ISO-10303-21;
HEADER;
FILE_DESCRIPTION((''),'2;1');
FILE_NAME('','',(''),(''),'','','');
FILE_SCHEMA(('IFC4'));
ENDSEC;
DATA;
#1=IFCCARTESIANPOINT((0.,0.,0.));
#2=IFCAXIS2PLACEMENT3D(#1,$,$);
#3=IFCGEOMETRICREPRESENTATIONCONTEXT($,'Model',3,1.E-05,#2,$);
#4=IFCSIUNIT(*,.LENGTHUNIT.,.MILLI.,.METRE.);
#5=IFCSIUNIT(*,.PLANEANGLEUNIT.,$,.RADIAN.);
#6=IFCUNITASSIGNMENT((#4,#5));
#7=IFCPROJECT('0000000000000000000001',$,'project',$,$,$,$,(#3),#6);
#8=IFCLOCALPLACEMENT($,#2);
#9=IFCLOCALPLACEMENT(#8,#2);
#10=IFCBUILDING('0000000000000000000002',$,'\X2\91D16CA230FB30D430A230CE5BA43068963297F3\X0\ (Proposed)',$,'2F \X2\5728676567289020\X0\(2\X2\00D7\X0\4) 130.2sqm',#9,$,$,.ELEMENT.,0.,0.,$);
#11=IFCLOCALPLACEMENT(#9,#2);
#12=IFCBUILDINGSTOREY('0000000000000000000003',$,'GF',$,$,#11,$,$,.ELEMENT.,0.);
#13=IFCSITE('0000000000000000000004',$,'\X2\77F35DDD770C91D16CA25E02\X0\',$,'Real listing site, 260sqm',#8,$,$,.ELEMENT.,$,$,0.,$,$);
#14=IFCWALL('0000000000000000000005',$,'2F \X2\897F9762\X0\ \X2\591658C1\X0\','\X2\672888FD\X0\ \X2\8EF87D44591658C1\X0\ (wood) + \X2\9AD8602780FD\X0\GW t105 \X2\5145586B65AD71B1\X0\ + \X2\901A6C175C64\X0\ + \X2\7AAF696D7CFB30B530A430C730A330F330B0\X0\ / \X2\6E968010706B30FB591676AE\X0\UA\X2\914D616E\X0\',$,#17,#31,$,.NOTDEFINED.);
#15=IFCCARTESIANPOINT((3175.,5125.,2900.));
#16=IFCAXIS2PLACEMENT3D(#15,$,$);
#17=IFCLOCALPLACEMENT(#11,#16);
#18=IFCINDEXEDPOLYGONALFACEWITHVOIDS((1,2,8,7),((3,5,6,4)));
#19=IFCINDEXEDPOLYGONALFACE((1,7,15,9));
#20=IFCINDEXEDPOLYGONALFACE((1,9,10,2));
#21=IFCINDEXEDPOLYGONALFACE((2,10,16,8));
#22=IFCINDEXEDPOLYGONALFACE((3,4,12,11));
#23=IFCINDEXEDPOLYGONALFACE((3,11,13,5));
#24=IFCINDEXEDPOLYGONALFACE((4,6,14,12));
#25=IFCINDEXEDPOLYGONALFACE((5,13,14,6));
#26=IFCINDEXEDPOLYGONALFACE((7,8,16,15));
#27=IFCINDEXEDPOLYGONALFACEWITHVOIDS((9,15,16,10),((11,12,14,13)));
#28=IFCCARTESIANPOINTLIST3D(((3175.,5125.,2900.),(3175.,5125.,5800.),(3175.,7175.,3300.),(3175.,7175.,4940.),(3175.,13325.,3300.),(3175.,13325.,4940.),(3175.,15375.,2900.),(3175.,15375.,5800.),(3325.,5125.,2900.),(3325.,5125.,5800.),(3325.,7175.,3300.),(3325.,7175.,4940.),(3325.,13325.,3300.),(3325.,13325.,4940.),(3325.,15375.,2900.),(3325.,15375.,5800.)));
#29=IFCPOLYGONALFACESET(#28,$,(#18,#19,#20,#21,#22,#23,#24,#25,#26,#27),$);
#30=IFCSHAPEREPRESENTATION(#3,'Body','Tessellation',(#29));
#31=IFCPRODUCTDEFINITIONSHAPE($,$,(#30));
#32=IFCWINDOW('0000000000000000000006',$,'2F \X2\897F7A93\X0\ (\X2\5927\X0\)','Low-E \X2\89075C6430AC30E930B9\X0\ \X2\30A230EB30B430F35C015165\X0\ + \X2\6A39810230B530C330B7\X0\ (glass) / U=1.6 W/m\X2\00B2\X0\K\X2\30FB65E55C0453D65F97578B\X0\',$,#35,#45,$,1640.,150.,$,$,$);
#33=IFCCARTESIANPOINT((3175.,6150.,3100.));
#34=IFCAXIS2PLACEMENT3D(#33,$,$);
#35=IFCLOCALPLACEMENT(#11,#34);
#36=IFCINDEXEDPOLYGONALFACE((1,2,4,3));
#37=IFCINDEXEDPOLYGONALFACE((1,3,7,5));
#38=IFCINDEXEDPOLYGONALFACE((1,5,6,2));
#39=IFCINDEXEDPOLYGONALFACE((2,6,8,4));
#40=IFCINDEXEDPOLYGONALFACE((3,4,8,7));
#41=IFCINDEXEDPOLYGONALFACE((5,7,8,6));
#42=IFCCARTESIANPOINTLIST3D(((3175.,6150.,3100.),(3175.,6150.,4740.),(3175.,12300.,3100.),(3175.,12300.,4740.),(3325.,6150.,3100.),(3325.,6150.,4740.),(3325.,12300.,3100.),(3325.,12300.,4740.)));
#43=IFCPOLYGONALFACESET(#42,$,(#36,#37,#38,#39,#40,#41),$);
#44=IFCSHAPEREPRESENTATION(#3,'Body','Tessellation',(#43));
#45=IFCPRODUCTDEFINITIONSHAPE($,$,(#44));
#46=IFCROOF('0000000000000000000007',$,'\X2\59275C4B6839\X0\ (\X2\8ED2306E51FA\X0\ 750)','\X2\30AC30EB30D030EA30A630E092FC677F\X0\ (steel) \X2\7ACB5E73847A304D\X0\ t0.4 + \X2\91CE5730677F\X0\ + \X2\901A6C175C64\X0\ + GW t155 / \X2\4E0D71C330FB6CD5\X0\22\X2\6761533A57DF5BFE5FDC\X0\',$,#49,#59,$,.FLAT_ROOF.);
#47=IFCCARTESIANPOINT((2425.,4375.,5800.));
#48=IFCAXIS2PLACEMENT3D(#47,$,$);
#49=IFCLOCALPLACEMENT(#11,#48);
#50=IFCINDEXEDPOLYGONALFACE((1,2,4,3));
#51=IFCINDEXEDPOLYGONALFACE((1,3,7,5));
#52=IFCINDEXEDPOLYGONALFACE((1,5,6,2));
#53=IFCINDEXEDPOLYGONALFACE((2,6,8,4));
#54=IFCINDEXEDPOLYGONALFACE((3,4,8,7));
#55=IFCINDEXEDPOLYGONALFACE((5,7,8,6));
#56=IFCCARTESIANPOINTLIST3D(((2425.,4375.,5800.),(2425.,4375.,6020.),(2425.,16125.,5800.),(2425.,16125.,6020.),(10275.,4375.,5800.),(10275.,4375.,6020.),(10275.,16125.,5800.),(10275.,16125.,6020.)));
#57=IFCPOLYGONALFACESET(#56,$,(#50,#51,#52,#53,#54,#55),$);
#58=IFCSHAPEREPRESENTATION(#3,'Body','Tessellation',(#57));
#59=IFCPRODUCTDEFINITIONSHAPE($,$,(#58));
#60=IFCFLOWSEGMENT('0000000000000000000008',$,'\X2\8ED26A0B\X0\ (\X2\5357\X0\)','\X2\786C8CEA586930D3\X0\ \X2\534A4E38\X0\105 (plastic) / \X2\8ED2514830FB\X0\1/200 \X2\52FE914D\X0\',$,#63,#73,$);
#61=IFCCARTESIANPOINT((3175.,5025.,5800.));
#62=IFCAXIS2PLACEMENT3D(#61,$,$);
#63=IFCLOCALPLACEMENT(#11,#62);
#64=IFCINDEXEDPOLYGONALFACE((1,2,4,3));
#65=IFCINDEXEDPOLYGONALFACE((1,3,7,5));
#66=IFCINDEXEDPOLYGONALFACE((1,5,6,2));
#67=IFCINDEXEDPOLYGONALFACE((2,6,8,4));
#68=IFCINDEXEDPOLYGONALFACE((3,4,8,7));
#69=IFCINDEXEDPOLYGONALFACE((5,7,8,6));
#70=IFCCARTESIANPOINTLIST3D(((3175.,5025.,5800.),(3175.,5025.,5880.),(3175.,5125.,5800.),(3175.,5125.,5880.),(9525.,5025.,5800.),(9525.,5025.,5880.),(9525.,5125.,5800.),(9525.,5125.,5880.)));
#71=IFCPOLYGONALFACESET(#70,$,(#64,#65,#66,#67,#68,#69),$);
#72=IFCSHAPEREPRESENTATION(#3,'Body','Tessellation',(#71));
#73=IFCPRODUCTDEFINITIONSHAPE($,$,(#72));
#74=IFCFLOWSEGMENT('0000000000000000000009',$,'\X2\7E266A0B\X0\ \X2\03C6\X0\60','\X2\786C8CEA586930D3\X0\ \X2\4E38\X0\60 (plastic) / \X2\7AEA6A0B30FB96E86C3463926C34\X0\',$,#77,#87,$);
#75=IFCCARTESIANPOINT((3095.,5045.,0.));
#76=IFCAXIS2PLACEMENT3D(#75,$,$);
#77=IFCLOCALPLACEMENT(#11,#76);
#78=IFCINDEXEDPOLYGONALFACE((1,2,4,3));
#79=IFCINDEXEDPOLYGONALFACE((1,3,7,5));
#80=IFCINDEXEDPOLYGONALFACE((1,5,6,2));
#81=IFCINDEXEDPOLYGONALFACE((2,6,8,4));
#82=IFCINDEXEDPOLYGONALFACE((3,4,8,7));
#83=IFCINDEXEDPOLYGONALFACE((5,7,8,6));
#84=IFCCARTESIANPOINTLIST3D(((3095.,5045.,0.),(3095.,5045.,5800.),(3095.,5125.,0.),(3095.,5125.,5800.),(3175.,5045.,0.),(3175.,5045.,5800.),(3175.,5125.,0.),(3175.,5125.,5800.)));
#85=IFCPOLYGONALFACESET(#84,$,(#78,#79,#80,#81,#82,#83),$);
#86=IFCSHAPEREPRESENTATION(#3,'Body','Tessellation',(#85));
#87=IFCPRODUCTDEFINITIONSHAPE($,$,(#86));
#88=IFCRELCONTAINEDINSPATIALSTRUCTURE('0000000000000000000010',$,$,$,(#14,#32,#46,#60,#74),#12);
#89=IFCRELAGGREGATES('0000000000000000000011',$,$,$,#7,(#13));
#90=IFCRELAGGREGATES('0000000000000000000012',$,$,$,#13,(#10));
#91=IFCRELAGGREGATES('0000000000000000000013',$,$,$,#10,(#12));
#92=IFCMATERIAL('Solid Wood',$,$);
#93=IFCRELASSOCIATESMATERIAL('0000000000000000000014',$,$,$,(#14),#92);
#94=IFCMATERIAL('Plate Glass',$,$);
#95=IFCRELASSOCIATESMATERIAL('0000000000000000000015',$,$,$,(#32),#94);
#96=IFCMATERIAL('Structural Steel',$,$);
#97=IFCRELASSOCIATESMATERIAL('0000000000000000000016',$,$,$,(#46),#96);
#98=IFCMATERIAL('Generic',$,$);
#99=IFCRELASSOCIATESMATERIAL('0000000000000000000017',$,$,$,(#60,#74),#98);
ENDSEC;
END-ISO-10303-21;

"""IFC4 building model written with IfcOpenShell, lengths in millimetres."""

from ifc_helpers import new_model, si_unit, frame, frame_2d, origin, place, context, project, spatial, rectangle, extrude, material, element, fill, save


model = new_model("IFC4")

# Units and contexts
model_context = context("Model", 3, precision=1e-05, world=origin())
ifc_project = project(units=[si_unit("LENGTHUNIT", "METRE", prefix="MILLI"), si_unit("PLANEANGLEUNIT", "RADIAN")], contexts=[model_context])

# Site, building, storey
site_placement = place(None, origin())
site = spatial("IfcSite", under=ifc_project, at=site_placement, Name="石川県金沢市", ObjectType="Real listing site, 260sqm", CompositionType="ELEMENT", RefElevation=0.0)
building_placement = place(site_placement, origin())
building = spatial("IfcBuilding", under=site, at=building_placement, Name="金沢・ピアノ室と防音 (Proposed)", ObjectType="2F 在来木造(2×4) 130.2sqm", CompositionType="ELEMENT", ElevationOfRefHeight=0.0, ElevationOfTerrain=0.0)
storey_placement = place(building_placement, origin())
storey = spatial("IfcBuildingStorey", under=building, at=storey_placement, Name="GF", CompositionType="ELEMENT", Elevation=0.0)

# Shared definitions
ifc_material_1 = material(Name="Solid Wood")

# Shared definitions
ifc_material_2 = material(Name="Plate Glass")

# Wall, opening, window
wall_1_placement = place(storey_placement, frame((3175.0, 5125.0, 2900.0)))
wall_1 = element("IfcWall", 1, at=wall_1_placement, inside=storey, material=ifc_material_1, Name="2F 西面 外壁", Description="木製 軸組外壁 (wood) + 高性能GW t105 充填断熱 + 通気層 + 窯業系サイディング / 準耐火・外皮UA配慮", PredefinedType="NOTDEFINED", context=model_context, shape_type="SweptSolid", body=[
    extrude(rectangle(XDim=150.0, YDim=10250.0, at=frame_2d((75.0, 5125.0))), frame((3175.0, 5125.0, 2900.0)), (0.0, 0.0, 1.0), 2900.0),
])
opening_1_placement = place(storey_placement, frame((3175.0, 6150.0, 3100.0)))
opening_1 = element("IfcOpeningElement", 2, at=opening_1_placement, cuts=wall_1, PredefinedType="NOTDEFINED", context=model_context, shape_type="SweptSolid", body=[
    extrude(rectangle(XDim=150.0, YDim=6150.0, at=frame_2d((75.0, 3075.0))), frame((3175.0, 6150.0, 3100.0)), (0.0, 0.0, 1.0), 1640.0),
])
window_1_placement = place(storey_placement, frame((3175.0, 6150.0, 3100.0)))
window_1 = element("IfcWindow", 3, at=window_1_placement, inside=storey, material=ifc_material_2, Name="2F 西窓 (大)", Description="Low-E 複層ガラス アルゴン封入 + 樹脂サッシ (glass) / U=1.6 W/m²K・日射取得型", OverallHeight=1640.0, OverallWidth=150.0, context=model_context, shape_type="SweptSolid", body=[
    extrude(rectangle(XDim=150.0, YDim=6150.0, at=frame_2d((75.0, 3075.0))), frame((3175.0, 6150.0, 3100.0)), (0.0, 0.0, 1.0), 1640.0),
])
fill(opening_1, window_1)

# Roof
ifc_material_3 = material(Name="Structural Steel")
roof_placement = place(storey_placement, frame((2425.0, 4375.0, 5800.0)))
element("IfcRoof", 4, at=roof_placement, inside=storey, material=ifc_material_3, Name="大屋根 (軒の出 750)", Description="ガルバリウム鋼板 (steel) 立平葺き t0.4 + 野地板 + 通気層 + GW t155 / 不燃・法22条区域対応", PredefinedType="FLAT_ROOF", context=model_context, shape_type="SweptSolid", body=[
    extrude(rectangle(XDim=7850.0, YDim=11750.0, at=frame_2d((3925.0, 5875.0))), frame((2425.0, 4375.0, 5800.0)), (0.0, 0.0, 1.0), 220.0),
])

# Flow segments
ifc_material_4 = material(Name="Generic")
flow_segment_1_placement = place(storey_placement, frame((3175.0, 5025.0, 5800.0)))
element("IfcFlowSegment", 5, at=flow_segment_1_placement, inside=storey, material=ifc_material_4, Name="軒樋 (南)", Description="硬質塩ビ 半丸105 (plastic) / 軒先・1/200 勾配", context=model_context, shape_type="SweptSolid", body=[
    extrude(rectangle(XDim=6350.0, YDim=100.0, at=frame_2d((3175.0, 50.0))), frame((3175.0, 5025.0, 5800.0)), (0.0, 0.0, 1.0), 80.0),
])
flow_segment_2_placement = place(storey_placement, frame((3095.0, 5045.0, 0.0)))
element("IfcFlowSegment", 6, at=flow_segment_2_placement, inside=storey, material=ifc_material_4, Name="縦樋 φ60", Description="硬質塩ビ 丸60 (plastic) / 竪樋・雨水排水", context=model_context, shape_type="SweptSolid", body=[
    extrude(rectangle(XDim=80.0, YDim=80.0, at=frame_2d((40.0, 40.0))), frame((3095.0, 5045.0, 0.0)), (0.0, 0.0, 1.0), 5800.0),
])

save(model, "model.ifc")
